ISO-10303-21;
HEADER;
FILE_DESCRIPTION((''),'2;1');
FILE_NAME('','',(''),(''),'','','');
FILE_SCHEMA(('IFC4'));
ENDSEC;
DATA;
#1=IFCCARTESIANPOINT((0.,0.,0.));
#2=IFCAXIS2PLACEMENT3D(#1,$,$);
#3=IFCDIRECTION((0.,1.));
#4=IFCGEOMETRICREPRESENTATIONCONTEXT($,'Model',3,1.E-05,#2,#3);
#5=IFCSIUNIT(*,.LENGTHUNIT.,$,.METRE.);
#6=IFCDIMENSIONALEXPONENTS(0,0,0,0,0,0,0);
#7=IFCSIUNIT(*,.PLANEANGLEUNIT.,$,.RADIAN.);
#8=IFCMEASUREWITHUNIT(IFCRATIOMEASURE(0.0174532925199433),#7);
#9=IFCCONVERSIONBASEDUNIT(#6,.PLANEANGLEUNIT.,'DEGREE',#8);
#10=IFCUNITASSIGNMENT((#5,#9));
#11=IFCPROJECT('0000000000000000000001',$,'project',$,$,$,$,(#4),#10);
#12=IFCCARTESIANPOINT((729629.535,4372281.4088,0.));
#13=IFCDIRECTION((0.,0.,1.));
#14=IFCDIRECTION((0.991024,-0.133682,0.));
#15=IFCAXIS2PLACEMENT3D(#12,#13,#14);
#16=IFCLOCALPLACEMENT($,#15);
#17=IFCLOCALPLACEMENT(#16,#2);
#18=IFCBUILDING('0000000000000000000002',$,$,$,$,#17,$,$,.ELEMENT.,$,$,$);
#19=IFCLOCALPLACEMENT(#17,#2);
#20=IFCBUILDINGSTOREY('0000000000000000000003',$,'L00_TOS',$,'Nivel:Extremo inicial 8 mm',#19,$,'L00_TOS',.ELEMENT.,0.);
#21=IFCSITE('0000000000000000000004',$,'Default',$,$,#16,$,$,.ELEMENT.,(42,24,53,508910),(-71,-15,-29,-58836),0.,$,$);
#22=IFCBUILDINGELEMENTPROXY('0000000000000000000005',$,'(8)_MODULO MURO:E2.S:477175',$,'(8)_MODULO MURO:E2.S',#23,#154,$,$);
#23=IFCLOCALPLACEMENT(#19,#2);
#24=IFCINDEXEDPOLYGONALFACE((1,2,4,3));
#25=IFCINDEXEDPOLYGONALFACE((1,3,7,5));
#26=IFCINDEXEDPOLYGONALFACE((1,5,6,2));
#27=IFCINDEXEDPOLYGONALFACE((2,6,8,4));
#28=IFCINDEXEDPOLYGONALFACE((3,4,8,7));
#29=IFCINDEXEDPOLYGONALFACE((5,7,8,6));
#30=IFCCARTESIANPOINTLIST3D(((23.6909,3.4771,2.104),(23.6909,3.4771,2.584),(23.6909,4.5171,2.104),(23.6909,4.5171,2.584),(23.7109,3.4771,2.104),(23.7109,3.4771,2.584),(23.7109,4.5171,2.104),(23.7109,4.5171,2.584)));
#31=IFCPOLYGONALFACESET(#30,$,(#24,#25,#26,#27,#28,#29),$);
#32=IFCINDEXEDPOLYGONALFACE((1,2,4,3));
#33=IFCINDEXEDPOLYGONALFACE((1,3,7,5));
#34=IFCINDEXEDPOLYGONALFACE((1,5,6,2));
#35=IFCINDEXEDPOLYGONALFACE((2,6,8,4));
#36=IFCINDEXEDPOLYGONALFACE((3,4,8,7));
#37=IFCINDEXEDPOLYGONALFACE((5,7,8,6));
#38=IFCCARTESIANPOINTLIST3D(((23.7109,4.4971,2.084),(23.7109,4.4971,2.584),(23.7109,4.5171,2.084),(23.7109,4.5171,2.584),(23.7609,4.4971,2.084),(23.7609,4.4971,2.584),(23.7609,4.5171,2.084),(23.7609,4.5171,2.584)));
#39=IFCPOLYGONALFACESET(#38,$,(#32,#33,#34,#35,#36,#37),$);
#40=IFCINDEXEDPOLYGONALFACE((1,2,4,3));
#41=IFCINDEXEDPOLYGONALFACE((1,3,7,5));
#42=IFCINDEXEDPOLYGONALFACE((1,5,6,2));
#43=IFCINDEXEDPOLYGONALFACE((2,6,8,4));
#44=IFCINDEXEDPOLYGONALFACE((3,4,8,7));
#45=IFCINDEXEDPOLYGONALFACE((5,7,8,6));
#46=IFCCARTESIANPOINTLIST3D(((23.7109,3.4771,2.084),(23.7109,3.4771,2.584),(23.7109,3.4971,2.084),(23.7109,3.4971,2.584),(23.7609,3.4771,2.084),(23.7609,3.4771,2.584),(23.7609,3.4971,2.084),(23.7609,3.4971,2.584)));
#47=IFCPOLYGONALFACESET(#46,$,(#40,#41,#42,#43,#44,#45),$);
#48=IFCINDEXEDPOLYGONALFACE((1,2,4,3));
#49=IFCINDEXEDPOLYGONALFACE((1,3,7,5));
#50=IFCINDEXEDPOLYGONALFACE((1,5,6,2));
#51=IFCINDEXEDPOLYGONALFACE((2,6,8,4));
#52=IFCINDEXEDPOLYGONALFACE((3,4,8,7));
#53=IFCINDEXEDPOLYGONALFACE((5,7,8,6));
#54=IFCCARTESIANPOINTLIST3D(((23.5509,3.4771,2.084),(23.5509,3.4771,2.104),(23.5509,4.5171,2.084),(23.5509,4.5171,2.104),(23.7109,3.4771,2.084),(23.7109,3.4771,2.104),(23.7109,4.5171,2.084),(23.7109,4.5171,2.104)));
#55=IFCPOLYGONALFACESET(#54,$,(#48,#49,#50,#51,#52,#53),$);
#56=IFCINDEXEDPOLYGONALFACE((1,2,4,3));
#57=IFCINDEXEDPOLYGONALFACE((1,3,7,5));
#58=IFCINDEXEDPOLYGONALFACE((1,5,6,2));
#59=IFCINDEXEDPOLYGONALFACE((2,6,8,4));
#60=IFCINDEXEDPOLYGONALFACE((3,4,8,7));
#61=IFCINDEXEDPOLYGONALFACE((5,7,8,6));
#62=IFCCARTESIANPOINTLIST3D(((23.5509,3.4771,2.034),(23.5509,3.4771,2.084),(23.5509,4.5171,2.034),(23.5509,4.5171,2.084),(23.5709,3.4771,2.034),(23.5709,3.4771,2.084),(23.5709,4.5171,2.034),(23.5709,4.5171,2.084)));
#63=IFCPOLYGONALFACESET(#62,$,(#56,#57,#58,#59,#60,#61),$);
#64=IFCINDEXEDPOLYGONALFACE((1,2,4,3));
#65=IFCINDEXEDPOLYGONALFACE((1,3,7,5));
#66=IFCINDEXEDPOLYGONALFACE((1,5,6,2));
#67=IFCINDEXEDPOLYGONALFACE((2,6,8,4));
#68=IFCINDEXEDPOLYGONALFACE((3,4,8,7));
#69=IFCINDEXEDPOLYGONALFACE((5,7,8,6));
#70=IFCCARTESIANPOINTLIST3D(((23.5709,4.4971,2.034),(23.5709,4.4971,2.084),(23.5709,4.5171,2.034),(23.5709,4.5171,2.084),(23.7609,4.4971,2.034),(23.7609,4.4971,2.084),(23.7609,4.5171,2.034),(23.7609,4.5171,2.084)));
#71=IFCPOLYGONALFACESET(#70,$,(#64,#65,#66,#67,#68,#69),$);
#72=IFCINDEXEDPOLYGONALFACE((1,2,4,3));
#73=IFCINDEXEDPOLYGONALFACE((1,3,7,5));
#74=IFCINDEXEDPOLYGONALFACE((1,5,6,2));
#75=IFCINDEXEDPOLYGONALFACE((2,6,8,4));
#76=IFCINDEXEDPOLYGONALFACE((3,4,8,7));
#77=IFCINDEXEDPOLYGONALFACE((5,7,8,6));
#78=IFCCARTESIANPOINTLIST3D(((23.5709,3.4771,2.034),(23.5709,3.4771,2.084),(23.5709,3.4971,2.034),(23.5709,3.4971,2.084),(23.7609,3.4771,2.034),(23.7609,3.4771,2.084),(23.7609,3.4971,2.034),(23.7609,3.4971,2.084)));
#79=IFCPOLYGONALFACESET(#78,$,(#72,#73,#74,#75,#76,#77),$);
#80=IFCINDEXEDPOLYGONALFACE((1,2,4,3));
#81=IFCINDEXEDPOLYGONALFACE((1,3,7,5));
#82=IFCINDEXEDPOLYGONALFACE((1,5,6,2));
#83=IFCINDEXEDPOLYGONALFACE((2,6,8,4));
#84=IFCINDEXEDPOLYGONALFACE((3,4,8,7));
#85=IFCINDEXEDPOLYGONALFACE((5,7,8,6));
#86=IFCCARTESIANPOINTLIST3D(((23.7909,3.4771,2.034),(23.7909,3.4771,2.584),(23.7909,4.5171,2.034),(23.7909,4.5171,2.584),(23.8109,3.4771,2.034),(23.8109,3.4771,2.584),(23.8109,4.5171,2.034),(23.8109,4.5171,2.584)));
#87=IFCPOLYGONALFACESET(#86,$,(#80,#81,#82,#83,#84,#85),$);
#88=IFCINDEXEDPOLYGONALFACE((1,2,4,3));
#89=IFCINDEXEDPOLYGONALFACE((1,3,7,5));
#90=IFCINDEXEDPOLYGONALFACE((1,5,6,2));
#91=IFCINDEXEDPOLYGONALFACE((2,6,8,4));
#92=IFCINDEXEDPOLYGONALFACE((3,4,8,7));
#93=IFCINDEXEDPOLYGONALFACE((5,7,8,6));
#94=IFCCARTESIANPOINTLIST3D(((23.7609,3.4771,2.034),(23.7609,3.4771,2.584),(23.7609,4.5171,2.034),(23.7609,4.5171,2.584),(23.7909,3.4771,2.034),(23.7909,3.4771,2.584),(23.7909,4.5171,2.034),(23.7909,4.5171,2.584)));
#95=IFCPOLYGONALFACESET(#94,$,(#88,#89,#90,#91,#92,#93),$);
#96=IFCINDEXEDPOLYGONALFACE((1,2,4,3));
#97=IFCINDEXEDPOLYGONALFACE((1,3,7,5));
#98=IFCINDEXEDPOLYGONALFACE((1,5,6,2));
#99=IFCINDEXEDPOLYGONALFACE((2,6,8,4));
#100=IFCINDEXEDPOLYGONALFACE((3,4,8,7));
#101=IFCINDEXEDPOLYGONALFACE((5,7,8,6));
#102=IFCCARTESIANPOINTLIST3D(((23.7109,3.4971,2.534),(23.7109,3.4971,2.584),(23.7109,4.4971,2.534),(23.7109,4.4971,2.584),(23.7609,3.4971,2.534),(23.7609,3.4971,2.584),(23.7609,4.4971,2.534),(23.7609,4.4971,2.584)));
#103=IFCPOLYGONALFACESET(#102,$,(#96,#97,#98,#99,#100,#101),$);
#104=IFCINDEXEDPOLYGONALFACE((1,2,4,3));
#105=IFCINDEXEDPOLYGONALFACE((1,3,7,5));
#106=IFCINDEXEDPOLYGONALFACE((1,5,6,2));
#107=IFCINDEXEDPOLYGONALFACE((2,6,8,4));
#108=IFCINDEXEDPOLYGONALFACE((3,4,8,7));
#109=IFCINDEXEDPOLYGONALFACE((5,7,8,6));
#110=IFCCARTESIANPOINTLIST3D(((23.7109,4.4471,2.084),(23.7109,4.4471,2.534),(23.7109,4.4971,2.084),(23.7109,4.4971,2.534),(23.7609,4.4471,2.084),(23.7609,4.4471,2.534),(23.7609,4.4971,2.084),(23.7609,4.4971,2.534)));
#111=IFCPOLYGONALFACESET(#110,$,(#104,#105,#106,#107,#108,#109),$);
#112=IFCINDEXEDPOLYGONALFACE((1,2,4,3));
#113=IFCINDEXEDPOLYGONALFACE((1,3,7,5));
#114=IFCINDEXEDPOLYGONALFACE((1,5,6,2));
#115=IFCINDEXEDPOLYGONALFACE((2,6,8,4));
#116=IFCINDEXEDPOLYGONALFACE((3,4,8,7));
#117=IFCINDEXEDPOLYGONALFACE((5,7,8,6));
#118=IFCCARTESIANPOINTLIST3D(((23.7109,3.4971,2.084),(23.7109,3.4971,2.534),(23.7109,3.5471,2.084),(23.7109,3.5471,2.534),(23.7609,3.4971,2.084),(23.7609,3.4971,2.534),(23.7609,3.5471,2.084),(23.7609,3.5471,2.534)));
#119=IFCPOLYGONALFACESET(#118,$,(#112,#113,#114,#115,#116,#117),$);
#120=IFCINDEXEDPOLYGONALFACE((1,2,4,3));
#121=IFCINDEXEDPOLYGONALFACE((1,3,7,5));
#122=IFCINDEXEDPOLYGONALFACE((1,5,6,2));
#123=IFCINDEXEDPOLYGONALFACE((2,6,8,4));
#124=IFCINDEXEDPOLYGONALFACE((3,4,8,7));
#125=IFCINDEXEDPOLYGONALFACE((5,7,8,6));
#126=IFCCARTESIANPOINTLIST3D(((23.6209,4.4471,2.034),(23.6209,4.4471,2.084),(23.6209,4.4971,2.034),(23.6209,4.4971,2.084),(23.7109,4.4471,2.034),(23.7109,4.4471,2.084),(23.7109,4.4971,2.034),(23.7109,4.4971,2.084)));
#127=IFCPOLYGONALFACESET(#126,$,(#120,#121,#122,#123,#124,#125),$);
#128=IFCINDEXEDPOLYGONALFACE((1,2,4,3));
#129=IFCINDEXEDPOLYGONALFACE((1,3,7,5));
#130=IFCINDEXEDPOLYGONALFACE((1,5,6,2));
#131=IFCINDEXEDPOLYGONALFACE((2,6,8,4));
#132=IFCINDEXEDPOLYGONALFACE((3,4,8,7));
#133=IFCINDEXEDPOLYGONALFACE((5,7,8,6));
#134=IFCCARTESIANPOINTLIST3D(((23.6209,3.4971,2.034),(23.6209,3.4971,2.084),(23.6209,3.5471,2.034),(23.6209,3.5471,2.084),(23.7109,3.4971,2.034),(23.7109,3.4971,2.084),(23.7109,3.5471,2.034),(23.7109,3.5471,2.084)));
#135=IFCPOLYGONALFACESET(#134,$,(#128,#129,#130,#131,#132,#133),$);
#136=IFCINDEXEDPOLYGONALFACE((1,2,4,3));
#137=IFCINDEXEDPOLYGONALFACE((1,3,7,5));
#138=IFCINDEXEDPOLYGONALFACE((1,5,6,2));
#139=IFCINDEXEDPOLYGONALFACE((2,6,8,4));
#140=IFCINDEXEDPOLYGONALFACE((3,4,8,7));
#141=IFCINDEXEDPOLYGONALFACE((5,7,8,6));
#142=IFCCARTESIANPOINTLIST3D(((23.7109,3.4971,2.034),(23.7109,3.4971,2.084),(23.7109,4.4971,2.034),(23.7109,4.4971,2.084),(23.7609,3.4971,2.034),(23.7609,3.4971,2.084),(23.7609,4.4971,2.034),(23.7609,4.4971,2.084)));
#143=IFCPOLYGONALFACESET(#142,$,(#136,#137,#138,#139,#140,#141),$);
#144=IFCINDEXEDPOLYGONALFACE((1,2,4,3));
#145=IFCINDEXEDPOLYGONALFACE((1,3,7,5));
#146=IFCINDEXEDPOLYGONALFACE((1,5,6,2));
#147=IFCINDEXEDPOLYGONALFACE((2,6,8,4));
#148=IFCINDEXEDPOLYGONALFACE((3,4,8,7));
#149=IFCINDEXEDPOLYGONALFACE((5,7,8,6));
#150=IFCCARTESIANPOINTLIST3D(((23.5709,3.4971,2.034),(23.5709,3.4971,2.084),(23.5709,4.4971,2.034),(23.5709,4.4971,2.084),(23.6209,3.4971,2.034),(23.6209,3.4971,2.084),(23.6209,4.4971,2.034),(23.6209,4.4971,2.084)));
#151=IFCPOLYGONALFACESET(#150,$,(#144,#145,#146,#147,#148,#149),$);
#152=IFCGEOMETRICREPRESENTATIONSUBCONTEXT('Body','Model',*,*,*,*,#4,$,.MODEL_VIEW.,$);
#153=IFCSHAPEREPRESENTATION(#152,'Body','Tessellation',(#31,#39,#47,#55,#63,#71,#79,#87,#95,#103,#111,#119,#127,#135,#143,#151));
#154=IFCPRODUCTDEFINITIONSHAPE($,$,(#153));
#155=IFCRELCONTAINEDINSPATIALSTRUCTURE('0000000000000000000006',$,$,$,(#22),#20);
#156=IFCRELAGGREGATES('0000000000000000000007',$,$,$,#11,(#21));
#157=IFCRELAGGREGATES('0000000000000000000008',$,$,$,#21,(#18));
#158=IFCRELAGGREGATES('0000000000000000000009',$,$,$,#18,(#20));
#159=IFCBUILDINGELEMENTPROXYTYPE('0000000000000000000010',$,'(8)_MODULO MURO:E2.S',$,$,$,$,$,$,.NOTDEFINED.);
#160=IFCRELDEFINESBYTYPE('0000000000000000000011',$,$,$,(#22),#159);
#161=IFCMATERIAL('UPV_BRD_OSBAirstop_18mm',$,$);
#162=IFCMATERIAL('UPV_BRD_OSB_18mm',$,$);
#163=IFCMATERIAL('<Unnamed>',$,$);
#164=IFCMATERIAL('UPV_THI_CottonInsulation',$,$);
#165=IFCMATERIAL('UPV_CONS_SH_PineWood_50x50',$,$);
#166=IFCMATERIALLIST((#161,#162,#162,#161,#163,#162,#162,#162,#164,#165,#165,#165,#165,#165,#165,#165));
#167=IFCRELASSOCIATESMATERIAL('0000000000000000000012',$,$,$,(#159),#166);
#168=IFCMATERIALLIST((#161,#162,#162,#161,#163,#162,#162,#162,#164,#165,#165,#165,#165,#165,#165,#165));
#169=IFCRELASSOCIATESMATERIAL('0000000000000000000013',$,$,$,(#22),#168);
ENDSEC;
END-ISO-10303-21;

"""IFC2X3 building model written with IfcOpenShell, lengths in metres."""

from ifc_helpers import new_model, entity, si_unit, converted_unit, direction, frame, frame_2d, origin, origin_2d_with_axis, place, context, subcontext, project, spatial, rectangle, extrude, source, transform, mapped, material, material_list, type_object, type_shapes, element, save


model = new_model("IFC2X3")

# Units and contexts
model_context = context("Model", 3, precision=1e-05, world=origin(), true_north=direction((0.0, 1.0)))
body_context = subcontext(model_context, "Body", "Model", "MODEL_VIEW")
ifc_project = project(units=[si_unit("LENGTHUNIT", "METRE"), converted_unit("PLANEANGLEUNIT", "DEGREE", entity("IfcRatioMeasure", 0.0174532925199433), si_unit("PLANEANGLEUNIT", "RADIAN"), dimensions=[0, 0, 0, 0, 0, 0, 0])], contexts=[model_context])

# Site, building, storey
site_placement = place(None, frame((729629.535, 4372281.4088, 0.0), z_axis=(0.0, 0.0, 1.0), x_axis=(0.991024, -0.133682, 0.0)))
site = spatial("IfcSite", under=ifc_project, at=site_placement, Name="Default", CompositionType="ELEMENT", RefLatitude=(42, 24, 53, 508910), RefLongitude=(-71, -15, -29, -58836), RefElevation=0.0)
building_placement = place(site_placement, origin())
building = spatial("IfcBuilding", under=site, at=building_placement, CompositionType="ELEMENT")
storey_placement = place(building_placement, origin())
storey = spatial("IfcBuildingStorey", under=building, at=storey_placement, Name="L00_TOS", ObjectType="Nivel:Extremo inicial 8 mm", LongName="L00_TOS", CompositionType="ELEMENT", Elevation=0.0)

# Building element proxy
ifc_material_1 = material(Name="UPV_BRD_OSBAirstop_18mm")
ifc_material_2 = material(Name="UPV_BRD_OSB_18mm")
ifc_material_3 = material(Name="UPV_THI_CottonInsulation")
ifc_material_4 = material(Name="<Unnamed>")
ifc_material_5 = material(Name="UPV_CONS_SH_PineWood_50x50")
ifc_material_list_1 = material_list([ifc_material_1, ifc_material_2, ifc_material_2, ifc_material_1, ifc_material_4, ifc_material_2, ifc_material_2, ifc_material_2, ifc_material_3, ifc_material_5, ifc_material_5, ifc_material_5, ifc_material_5, ifc_material_5, ifc_material_5, ifc_material_5])
ifc_material_list_2 = material_list([ifc_material_1, ifc_material_2, ifc_material_2, ifc_material_1, ifc_material_4, ifc_material_2, ifc_material_2, ifc_material_2, ifc_material_3, ifc_material_5, ifc_material_5, ifc_material_5, ifc_material_5, ifc_material_5, ifc_material_5, ifc_material_5])
building_element_proxy_type_1 = type_object("IfcBuildingElementProxyType", Name="(8)_MODULO MURO:E2.S", PredefinedType="NOTDEFINED", material=ifc_material_list_2)
shared_shape_1 = source(origin(), body_context, "Body", "SweptSolid", [
    extrude(rectangle(XDim=1.04, YDim=0.02, at=frame_2d((0.0, 0.0), x_axis=(1.0, 0.0))), frame((0.0, 0.035, 0.07), z_axis=(0.0, 0.0, 1.0), x_axis=(-1.0, 0.0, 0.0)), (0.0, 0.0, 1.0), 0.48),
    extrude(rectangle(XDim=0.05, YDim=0.02, at=origin_2d_with_axis()), frame((-0.51, 0.07, 0.05), z_axis=(0.0, 0.0, 1.0), x_axis=(0.0, -1.0, 0.0)), (0.0, 0.0, 1.0), 0.5),
    extrude(rectangle(XDim=0.05, YDim=0.02, at=origin_2d_with_axis()), frame((0.51, 0.07, 0.05), z_axis=(0.0, 0.0, 1.0), x_axis=(0.0, -1.0, 0.0)), (0.0, 0.0, 1.0), 0.5),
    extrude(rectangle(XDim=1.04, YDim=0.16, at=origin_2d_with_axis()), frame((0.0, -0.035, 0.05)), (0.0, 0.0, 1.0), 0.02),
    extrude(rectangle(XDim=1.04, YDim=0.02, at=origin_2d_with_axis()), frame((0.0, -0.105, 0.0), z_axis=(0.0, 0.0, 1.0), x_axis=(-1.0, 0.0, 0.0)), (0.0, 0.0, 1.0), 0.05),
    extrude(rectangle(XDim=0.19, YDim=0.02, at=origin_2d_with_axis()), frame((-0.51, 0.0, 0.0), z_axis=(0.0, 0.0, 1.0), x_axis=(0.0, -1.0, 0.0)), (0.0, 0.0, 1.0), 0.05),
    extrude(rectangle(XDim=0.19, YDim=0.02, at=origin_2d_with_axis()), frame((0.51, 0.0, 0.0), z_axis=(0.0, 0.0, 1.0), x_axis=(0.0, -1.0, 0.0)), (0.0, 0.0, 1.0), 0.05),
    extrude(rectangle(XDim=1.04, YDim=0.02, at=frame_2d((0.0, 0.0), x_axis=(1.0, 0.0))), frame((0.0, 0.135, 0.0), z_axis=(0.0, 0.0, 1.0), x_axis=(-1.0, 0.0, 0.0)), (0.0, 0.0, 1.0), 0.55),
    extrude(rectangle(XDim=1.04, YDim=0.03, at=origin_2d_with_axis()), frame((0.0, 0.11, 0.0)), (0.0, 0.0, 1.0), 0.55),
    extrude(rectangle(XDim=0.05, YDim=1.0, at=origin_2d_with_axis()), frame((0.0, 0.07, 0.5), z_axis=(0.0, 0.0, 1.0), x_axis=(0.0, -1.0, 0.0)), (0.0, 0.0, 1.0), 0.05),
    extrude(rectangle(XDim=0.05, YDim=0.05, at=frame_2d((0.0, 0.0), x_axis=(1.0, 0.0))), frame((-0.475, 0.07, 0.05)), (0.0, 0.0, 1.0), 0.45),
    extrude(rectangle(XDim=0.05, YDim=0.05, at=origin_2d_with_axis()), frame((0.475, 0.07, 0.05), z_axis=(0.0, 0.0, 1.0), x_axis=(0.0, -1.0, 0.0)), (0.0, 0.0, 1.0), 0.45),
    extrude(rectangle(XDim=0.09, YDim=0.05, at=origin_2d_with_axis()), frame((-0.475, 0.0, 0.0), z_axis=(0.0, 0.0, 1.0), x_axis=(0.0, -1.0, 0.0)), (0.0, 0.0, 1.0), 0.05),
    extrude(rectangle(XDim=0.09, YDim=0.05, at=origin_2d_with_axis()), frame((0.475, 0.0, 0.0), z_axis=(0.0, 0.0, 1.0), x_axis=(0.0, -1.0, 0.0)), (0.0, 0.0, 1.0), 0.05),
    extrude(rectangle(XDim=0.05, YDim=1.0, at=origin_2d_with_axis()), frame((0.0, 0.07, 0.0), z_axis=(0.0, 0.0, 1.0), x_axis=(0.0, -1.0, 0.0)), (0.0, 0.0, 1.0), 0.05),
    extrude(rectangle(XDim=0.05, YDim=1.0, at=origin_2d_with_axis()), frame((0.0, -0.07, 0.0), z_axis=(0.0, 0.0, 1.0), x_axis=(0.0, -1.0, 0.0)), (0.0, 0.0, 1.0), 0.05),
])
type_shapes(building_element_proxy_type_1, [shared_shape_1])
proxy_1_placement = place(storey_placement, frame((23.6659, 3.9971, 2.034), z_axis=(0.0, 0.0, 1.0), x_axis=(0.0, -1.0, 0.0)))
element("IfcBuildingElementProxy", 1, at=proxy_1_placement, inside=storey, type_object=building_element_proxy_type_1, material=ifc_material_list_1, Name="(8)_MODULO MURO:E2.S:477175", ObjectType="(8)_MODULO MURO:E2.S", context=body_context, shape_type="MappedRepresentation", body=[
    mapped(shared_shape_1, transform((0.0, 0.0, 0.0), scale=1.0)),
])

save(model, "model.ifc")
